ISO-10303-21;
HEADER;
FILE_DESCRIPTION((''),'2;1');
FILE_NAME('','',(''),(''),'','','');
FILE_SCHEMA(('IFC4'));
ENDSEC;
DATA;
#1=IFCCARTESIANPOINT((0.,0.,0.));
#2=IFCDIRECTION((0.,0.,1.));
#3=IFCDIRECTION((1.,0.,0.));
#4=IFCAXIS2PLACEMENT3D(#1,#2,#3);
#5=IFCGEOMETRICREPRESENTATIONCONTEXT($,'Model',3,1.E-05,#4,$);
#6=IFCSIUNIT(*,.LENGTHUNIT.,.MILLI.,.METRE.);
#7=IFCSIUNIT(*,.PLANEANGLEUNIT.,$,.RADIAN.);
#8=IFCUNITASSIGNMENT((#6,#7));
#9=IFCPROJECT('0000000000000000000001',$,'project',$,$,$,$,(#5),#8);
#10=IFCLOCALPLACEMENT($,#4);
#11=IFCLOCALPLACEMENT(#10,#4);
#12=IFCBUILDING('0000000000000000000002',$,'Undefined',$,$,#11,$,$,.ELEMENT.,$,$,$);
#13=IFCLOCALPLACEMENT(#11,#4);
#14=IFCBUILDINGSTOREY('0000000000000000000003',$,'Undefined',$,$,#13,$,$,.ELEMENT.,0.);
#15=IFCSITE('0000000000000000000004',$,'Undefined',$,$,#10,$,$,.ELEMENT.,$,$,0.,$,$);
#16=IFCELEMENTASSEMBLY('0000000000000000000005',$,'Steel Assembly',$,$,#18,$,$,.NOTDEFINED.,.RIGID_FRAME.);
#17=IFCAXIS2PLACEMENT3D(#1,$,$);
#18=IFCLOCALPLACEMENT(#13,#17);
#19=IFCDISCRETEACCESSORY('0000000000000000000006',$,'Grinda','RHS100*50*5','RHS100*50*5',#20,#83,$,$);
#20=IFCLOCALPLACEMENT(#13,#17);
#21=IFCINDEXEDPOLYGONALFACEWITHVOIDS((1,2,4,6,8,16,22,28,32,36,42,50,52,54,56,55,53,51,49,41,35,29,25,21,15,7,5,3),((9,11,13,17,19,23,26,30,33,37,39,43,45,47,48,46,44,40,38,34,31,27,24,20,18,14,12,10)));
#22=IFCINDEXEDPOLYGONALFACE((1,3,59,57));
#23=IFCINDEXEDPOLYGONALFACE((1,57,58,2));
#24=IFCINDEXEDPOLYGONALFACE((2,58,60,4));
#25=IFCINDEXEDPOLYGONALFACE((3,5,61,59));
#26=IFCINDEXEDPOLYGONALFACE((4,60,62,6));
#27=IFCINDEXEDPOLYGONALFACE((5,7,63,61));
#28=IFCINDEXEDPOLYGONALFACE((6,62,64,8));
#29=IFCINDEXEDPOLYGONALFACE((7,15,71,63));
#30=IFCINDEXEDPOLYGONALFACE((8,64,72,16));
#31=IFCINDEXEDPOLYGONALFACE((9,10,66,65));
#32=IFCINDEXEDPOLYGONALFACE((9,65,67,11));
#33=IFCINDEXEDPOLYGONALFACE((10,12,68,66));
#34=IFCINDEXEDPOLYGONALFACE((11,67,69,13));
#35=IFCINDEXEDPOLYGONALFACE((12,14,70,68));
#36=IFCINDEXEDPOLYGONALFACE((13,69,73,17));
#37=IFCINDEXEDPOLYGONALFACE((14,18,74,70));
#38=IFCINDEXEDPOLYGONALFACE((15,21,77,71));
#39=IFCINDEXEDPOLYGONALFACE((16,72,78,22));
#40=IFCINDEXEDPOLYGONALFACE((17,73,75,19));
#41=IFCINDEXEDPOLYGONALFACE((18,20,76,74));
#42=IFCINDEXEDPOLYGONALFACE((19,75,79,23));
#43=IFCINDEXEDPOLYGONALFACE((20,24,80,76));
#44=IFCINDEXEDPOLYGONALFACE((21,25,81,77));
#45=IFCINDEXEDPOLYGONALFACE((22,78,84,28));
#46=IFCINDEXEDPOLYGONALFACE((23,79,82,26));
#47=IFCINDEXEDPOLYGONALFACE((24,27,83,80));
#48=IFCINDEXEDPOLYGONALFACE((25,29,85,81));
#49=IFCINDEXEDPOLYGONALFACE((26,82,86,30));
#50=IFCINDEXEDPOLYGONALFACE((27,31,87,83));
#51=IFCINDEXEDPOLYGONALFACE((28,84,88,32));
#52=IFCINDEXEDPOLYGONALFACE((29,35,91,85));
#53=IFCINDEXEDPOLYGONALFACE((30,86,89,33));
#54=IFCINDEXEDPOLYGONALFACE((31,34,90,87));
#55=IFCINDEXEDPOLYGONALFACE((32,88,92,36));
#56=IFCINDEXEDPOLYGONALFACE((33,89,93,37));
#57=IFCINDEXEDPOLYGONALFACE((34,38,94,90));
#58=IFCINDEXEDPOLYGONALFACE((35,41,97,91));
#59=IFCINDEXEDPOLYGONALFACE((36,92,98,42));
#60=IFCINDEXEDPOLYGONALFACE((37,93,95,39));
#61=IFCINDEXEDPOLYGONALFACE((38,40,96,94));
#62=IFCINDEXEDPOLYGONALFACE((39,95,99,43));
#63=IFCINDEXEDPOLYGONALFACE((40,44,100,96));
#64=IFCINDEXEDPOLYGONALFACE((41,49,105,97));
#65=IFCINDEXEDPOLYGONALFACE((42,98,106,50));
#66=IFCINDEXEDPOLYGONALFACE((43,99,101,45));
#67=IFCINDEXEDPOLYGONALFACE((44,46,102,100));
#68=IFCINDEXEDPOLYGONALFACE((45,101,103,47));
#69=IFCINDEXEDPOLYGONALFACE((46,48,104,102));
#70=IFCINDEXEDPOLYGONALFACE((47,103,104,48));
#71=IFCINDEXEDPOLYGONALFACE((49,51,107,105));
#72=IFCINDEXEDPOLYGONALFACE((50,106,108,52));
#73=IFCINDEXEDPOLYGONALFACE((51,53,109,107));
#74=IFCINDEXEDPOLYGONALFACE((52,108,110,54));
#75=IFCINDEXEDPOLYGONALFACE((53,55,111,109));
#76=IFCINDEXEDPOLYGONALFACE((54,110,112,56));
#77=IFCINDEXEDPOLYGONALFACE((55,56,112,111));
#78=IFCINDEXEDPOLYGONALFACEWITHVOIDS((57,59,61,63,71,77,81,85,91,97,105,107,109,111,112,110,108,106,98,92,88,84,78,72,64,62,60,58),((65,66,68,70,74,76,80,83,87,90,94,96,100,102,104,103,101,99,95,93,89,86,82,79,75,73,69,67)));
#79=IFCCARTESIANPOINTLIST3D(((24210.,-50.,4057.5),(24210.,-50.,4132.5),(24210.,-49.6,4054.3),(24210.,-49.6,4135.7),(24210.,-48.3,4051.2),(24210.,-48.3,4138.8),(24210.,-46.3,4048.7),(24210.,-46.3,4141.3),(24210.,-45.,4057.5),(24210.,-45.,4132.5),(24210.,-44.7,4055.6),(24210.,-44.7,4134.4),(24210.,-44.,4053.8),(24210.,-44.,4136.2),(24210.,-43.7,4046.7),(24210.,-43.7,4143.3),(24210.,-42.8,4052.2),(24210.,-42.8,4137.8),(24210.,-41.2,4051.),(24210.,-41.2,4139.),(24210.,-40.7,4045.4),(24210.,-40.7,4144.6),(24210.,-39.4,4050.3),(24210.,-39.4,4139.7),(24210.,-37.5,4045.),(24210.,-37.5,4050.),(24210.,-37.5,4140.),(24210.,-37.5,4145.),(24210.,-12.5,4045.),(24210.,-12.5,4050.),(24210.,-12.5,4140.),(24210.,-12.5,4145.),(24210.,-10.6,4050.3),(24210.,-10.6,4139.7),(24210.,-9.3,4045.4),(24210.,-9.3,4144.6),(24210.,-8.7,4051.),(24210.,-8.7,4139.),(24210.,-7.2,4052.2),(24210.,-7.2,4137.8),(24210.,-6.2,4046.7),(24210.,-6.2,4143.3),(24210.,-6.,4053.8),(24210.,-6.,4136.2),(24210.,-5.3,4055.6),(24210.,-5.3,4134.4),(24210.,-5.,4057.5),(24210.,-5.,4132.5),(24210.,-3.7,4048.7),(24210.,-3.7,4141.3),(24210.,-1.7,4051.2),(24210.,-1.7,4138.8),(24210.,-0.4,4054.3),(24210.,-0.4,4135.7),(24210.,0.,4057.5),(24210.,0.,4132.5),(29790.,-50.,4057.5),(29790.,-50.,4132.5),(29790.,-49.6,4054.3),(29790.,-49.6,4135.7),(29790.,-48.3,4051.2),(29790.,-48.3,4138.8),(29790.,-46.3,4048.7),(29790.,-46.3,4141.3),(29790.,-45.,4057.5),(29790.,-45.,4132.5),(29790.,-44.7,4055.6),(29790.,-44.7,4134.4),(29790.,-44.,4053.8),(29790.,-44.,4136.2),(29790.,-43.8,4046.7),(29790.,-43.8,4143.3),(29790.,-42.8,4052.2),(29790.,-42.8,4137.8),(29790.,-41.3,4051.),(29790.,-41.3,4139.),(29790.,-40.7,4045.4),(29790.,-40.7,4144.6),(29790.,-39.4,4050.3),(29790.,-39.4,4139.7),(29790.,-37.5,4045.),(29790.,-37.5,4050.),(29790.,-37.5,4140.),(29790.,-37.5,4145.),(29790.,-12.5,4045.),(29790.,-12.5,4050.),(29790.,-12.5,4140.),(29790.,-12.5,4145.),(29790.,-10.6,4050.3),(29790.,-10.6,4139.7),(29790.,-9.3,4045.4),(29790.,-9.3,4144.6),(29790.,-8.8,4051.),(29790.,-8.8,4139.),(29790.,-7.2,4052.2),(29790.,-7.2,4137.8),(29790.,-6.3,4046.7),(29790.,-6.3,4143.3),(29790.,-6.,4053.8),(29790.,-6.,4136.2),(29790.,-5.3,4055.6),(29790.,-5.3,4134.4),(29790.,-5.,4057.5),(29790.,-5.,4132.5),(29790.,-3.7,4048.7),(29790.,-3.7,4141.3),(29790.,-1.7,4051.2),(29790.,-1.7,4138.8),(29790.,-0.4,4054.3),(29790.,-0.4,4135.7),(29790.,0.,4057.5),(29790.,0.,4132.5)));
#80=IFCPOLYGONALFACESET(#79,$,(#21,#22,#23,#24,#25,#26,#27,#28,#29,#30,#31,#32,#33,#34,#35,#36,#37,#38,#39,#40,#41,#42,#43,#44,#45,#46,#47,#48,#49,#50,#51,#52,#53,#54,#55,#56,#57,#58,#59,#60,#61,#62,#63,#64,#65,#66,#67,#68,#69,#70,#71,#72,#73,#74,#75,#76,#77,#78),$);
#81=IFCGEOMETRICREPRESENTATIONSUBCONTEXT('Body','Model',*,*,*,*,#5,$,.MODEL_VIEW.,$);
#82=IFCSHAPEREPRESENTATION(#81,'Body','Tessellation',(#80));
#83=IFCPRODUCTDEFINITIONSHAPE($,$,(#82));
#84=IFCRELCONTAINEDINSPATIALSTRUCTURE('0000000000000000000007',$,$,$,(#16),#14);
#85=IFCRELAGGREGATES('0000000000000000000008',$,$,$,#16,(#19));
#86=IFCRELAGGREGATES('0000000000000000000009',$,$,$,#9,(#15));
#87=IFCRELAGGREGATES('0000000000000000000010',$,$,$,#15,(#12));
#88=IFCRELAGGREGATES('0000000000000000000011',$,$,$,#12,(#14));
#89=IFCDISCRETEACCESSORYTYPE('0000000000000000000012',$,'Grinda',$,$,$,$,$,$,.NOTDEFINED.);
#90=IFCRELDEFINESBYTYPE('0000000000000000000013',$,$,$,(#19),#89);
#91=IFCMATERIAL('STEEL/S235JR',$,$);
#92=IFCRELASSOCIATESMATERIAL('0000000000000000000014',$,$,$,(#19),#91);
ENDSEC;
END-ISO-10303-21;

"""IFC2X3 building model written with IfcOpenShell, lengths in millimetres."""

from ifc_helpers import new_model, si_unit, frame, origin_with_axes, origin_2d_with_axis, place, context, subcontext, project, spatial, hollow_rectangle, extrude, material, type_object, element, aggregate, save


model = new_model("IFC2X3")

# Units and contexts
model_context = context("Model", 3, precision=1e-05, world=origin_with_axes())
body_context = subcontext(model_context, "Body", "Model", "MODEL_VIEW")
ifc_project = project(units=[si_unit("LENGTHUNIT", "METRE", prefix="MILLI"), si_unit("PLANEANGLEUNIT", "RADIAN")], contexts=[model_context])

# Site, building, storey
site_placement = place(None, origin_with_axes())
site = spatial("IfcSite", under=ifc_project, at=site_placement, Name="Undefined", CompositionType="ELEMENT", RefElevation=0.0)
building_placement = place(site_placement, origin_with_axes())
building = spatial("IfcBuilding", under=site, at=building_placement, Name="Undefined", CompositionType="ELEMENT")
storey_placement = place(building_placement, origin_with_axes())
storey = spatial("IfcBuildingStorey", under=building, at=storey_placement, Name="Undefined", CompositionType="ELEMENT", Elevation=0.0)

# Shared definitions
ifc_material_1 = material(Name="STEEL/S235JR")

# Element assembly
assembly_1_placement = place(storey_placement, origin_with_axes())
assembly_1 = element("IfcElementAssembly", 1, at=assembly_1_placement, inside=storey, Name="Steel Assembly", AssemblyPlace="NOTDEFINED", PredefinedType="RIGID_FRAME")

# Discrete accessory
discrete_accessory_type_1 = type_object("IfcDiscreteAccessoryType", Name="Grinda")
discrete_accessory_1_placement = place(assembly_1_placement, frame((29790.0, -25.0, 4095.0), z_axis=(0.0, 0.0, 1.0), x_axis=(-1.0, 0.0, 0.0)))
discrete_accessory_1 = element("IfcDiscreteAccessory", 2, at=discrete_accessory_1_placement, type_object=discrete_accessory_type_1, material=ifc_material_1, Name="Grinda", Description="RHS100*50*5", ObjectType="RHS100*50*5", context=body_context, shape_type="SweptSolid", body=[
    extrude(hollow_rectangle(XDim=50.0, YDim=100.0, WallThickness=5.0, InnerFilletRadius=7.5, OuterFilletRadius=12.5, at=origin_2d_with_axis()), frame((5580.0, 0.0, 0.0), z_axis=(-1.0, 0.0, 0.0), x_axis=(0.0, -1.0, 0.0)), (0.0, 0.0, 1.0), 5580.0),
])

aggregate(assembly_1, [discrete_accessory_1])

save(model, "model.ifc")
